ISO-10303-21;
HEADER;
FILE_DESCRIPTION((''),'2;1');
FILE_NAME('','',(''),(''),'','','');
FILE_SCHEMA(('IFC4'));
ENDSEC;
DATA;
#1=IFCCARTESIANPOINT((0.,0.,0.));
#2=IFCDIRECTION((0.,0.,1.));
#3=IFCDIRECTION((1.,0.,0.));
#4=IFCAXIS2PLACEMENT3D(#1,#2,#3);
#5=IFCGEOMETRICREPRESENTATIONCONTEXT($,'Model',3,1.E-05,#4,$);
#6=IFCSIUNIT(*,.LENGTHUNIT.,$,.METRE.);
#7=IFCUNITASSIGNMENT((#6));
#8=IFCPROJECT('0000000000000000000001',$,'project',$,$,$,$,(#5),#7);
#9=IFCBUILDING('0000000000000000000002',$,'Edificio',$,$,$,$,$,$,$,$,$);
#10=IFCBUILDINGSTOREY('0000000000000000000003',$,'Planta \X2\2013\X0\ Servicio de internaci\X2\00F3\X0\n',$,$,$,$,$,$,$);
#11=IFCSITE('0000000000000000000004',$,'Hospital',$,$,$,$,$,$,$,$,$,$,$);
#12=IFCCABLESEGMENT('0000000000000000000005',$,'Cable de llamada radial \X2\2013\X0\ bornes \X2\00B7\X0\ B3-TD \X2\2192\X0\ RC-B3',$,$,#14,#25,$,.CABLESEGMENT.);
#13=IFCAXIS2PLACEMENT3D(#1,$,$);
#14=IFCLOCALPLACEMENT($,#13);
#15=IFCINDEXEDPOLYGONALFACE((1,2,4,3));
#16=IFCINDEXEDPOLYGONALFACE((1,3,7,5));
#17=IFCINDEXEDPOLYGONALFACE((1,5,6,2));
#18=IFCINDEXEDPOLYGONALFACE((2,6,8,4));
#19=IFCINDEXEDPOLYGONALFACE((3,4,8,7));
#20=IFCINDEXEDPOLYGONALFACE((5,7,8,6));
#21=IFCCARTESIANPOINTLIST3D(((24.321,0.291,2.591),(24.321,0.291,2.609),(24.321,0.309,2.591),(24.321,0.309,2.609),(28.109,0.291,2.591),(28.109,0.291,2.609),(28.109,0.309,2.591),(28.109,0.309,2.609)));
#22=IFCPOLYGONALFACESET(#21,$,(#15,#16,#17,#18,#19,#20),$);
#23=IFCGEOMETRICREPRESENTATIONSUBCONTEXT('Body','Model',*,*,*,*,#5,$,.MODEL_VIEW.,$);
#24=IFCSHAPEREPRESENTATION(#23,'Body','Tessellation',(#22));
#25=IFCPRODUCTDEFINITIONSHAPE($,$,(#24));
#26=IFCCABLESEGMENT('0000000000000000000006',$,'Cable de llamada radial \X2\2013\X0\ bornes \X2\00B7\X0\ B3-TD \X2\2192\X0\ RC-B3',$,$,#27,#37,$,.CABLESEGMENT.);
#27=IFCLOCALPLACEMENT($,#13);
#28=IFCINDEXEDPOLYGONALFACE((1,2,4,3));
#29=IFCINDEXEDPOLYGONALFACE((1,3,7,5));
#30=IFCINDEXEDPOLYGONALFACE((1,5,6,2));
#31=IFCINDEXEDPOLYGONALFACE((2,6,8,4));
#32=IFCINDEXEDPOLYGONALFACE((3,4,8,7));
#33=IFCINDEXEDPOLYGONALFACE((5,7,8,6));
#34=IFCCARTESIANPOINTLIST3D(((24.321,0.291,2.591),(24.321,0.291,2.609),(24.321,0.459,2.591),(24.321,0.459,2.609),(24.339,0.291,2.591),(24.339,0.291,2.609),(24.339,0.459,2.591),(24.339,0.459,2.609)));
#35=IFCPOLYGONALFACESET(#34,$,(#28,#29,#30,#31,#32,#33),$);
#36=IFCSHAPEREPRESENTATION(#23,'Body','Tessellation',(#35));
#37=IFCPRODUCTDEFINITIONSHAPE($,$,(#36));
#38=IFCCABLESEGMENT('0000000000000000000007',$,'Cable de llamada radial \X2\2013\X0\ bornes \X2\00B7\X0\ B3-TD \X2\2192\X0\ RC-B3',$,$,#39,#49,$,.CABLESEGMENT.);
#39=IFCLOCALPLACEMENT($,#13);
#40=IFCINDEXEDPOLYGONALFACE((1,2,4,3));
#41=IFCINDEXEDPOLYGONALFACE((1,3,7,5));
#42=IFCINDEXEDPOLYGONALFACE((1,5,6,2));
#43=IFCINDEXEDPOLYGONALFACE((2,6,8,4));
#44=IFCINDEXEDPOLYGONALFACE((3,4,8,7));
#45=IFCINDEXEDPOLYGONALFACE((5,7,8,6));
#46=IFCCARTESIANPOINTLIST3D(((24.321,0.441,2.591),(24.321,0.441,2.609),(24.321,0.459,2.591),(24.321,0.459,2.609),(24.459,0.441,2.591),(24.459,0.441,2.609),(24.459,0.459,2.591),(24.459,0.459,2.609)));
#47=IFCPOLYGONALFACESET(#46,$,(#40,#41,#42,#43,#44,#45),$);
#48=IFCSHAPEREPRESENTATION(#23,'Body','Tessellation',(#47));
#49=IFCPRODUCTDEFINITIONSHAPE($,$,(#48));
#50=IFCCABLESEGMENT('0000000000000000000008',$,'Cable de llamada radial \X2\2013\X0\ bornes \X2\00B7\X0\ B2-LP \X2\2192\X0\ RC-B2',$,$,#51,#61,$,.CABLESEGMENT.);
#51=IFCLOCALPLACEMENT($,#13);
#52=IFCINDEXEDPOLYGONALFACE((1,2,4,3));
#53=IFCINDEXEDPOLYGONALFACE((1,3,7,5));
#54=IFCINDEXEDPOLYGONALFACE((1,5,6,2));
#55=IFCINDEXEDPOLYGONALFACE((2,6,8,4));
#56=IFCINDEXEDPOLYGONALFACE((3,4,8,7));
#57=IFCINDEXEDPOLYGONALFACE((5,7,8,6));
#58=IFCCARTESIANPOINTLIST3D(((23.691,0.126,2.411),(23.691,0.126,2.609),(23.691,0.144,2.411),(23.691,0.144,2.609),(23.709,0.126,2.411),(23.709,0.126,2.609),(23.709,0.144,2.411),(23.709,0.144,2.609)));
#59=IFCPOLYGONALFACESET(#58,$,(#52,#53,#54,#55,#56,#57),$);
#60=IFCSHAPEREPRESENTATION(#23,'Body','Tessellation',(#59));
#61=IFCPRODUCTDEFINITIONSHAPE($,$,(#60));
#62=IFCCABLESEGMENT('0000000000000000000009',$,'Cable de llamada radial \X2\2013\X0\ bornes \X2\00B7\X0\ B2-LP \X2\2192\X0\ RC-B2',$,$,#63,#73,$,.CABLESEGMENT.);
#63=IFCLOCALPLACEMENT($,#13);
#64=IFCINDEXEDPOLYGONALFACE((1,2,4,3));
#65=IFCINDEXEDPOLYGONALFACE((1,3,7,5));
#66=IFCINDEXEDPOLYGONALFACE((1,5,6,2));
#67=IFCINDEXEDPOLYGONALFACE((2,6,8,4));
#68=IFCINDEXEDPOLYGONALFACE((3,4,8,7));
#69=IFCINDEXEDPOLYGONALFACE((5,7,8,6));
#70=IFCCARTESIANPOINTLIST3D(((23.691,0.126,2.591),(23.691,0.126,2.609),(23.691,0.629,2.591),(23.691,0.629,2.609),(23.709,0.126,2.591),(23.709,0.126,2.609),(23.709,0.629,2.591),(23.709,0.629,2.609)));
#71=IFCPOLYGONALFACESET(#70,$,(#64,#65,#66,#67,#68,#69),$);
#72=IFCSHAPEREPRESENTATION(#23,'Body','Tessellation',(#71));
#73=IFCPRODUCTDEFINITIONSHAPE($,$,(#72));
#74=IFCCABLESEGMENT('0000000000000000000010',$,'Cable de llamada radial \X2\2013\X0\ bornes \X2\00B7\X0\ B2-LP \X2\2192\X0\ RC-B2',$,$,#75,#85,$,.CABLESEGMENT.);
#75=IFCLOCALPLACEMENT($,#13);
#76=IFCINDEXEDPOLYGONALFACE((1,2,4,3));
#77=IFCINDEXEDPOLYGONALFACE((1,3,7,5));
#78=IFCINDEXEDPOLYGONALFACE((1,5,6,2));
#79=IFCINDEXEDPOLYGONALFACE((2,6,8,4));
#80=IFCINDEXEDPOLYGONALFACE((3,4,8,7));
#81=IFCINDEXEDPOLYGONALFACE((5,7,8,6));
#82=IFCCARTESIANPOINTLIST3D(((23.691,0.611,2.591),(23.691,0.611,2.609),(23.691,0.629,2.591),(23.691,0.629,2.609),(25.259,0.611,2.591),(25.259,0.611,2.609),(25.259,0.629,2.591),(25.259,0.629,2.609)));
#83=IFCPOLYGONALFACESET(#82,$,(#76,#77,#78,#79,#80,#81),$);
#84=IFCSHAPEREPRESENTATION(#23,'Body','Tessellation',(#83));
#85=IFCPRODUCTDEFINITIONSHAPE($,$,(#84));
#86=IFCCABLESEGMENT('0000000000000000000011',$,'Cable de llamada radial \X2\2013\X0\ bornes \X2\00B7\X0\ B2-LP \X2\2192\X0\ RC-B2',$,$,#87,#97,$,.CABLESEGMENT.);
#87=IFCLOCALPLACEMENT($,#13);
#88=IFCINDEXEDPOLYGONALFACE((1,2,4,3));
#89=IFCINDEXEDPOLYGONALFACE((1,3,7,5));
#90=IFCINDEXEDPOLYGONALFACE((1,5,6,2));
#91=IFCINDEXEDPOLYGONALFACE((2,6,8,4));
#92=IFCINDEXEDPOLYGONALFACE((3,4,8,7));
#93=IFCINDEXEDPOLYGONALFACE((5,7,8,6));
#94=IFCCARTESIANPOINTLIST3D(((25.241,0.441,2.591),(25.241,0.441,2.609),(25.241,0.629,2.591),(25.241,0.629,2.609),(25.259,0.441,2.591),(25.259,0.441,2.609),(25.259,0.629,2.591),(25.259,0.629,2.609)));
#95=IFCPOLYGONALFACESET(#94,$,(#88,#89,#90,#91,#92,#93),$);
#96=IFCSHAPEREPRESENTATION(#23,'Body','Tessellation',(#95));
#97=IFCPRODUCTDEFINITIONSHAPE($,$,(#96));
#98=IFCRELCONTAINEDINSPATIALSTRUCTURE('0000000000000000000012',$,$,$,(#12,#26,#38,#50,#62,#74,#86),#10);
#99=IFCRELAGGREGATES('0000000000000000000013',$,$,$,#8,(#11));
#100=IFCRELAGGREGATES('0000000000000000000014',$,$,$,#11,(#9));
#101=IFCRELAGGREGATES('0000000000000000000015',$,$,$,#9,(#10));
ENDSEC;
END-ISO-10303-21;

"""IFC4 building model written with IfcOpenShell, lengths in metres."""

from ifc_helpers import new_model, si_unit, frame, origin_with_axes, context, subcontext, project, spatial, line, indexed_curve, outline, extrude, element, save


model = new_model("IFC4")

# Units and contexts
model_context = context("Model", 3, precision=1e-05, world=origin_with_axes())
body_context = subcontext(model_context, "Body", "Model", "MODEL_VIEW")
ifc_project = project(units=[si_unit("LENGTHUNIT", "METRE")], contexts=[model_context])

# Site, building, storey
site = spatial("IfcSite", under=ifc_project, Name="Hospital")
building = spatial("IfcBuilding", under=site, Name="Edificio")
storey = spatial("IfcBuildingStorey", under=building, Name="Planta – Servicio de internación")

# Cable segments
element("IfcCableSegment", 1, inside=storey, Name="Cable de llamada radial – bornes · B3-TD → RC-B3", PredefinedType="CABLESEGMENT", context=body_context, shape_type="SweptSolid", body=[
    extrude(outline(indexed_curve([(0.0, 0.0), (3.788, 0.0), (3.788, 0.018), (0.0, 0.018)], segments=[line(1, 2, 3, 4, 1)])), frame((24.321, 0.291, 2.591), z_axis=(0.0, 0.0, 1.0), x_axis=(1.0, 0.0, 0.0)), (0.0, 0.0, 1.0), 0.018),
])
element("IfcCableSegment", 2, inside=storey, Name="Cable de llamada radial – bornes · B3-TD → RC-B3", PredefinedType="CABLESEGMENT", context=body_context, shape_type="SweptSolid", body=[
    extrude(outline(indexed_curve([(0.0, 0.0), (0.018, 0.0), (0.018, 0.168), (0.0, 0.168)], segments=[line(1, 2, 3, 4, 1)])), frame((24.321, 0.291, 2.591), z_axis=(0.0, 0.0, 1.0), x_axis=(1.0, 0.0, 0.0)), (0.0, 0.0, 1.0), 0.018),
])
element("IfcCableSegment", 3, inside=storey, Name="Cable de llamada radial – bornes · B3-TD → RC-B3", PredefinedType="CABLESEGMENT", context=body_context, shape_type="SweptSolid", body=[
    extrude(outline(indexed_curve([(0.0, 0.0), (0.138, 0.0), (0.138, 0.018), (0.0, 0.018)], segments=[line(1, 2, 3, 4, 1)])), frame((24.321, 0.441, 2.591), z_axis=(0.0, 0.0, 1.0), x_axis=(1.0, 0.0, 0.0)), (0.0, 0.0, 1.0), 0.018),
])
element("IfcCableSegment", 4, inside=storey, Name="Cable de llamada radial – bornes · B2-LP → RC-B2", PredefinedType="CABLESEGMENT", context=body_context, shape_type="SweptSolid", body=[
    extrude(outline(indexed_curve([(0.0, 0.0), (0.018, 0.0), (0.018, 0.018), (0.0, 0.018)], segments=[line(1, 2, 3, 4, 1)])), frame((23.691, 0.126, 2.411), z_axis=(0.0, 0.0, 1.0), x_axis=(1.0, 0.0, 0.0)), (0.0, 0.0, 1.0), 0.198),
])
element("IfcCableSegment", 5, inside=storey, Name="Cable de llamada radial – bornes · B2-LP → RC-B2", PredefinedType="CABLESEGMENT", context=body_context, shape_type="SweptSolid", body=[
    extrude(outline(indexed_curve([(0.0, 0.0), (0.018, 0.0), (0.018, 0.503), (0.0, 0.503)], segments=[line(1, 2, 3, 4, 1)])), frame((23.691, 0.126, 2.591), z_axis=(0.0, 0.0, 1.0), x_axis=(1.0, 0.0, 0.0)), (0.0, 0.0, 1.0), 0.018),
])
element("IfcCableSegment", 6, inside=storey, Name="Cable de llamada radial – bornes · B2-LP → RC-B2", PredefinedType="CABLESEGMENT", context=body_context, shape_type="SweptSolid", body=[
    extrude(outline(indexed_curve([(0.0, 0.0), (1.568, 0.0), (1.568, 0.018), (0.0, 0.018)], segments=[line(1, 2, 3, 4, 1)])), frame((23.691, 0.611, 2.591), z_axis=(0.0, 0.0, 1.0), x_axis=(1.0, 0.0, 0.0)), (0.0, 0.0, 1.0), 0.018),
])
element("IfcCableSegment", 7, inside=storey, Name="Cable de llamada radial – bornes · B2-LP → RC-B2", PredefinedType="CABLESEGMENT", context=body_context, shape_type="SweptSolid", body=[
    extrude(outline(indexed_curve([(0.0, 0.0), (0.018, 0.0), (0.018, 0.188), (0.0, 0.188)], segments=[line(1, 2, 3, 4, 1)])), frame((25.241, 0.441, 2.591), z_axis=(0.0, 0.0, 1.0), x_axis=(1.0, 0.0, 0.0)), (0.0, 0.0, 1.0), 0.018),
])

save(model, "model.ifc")
